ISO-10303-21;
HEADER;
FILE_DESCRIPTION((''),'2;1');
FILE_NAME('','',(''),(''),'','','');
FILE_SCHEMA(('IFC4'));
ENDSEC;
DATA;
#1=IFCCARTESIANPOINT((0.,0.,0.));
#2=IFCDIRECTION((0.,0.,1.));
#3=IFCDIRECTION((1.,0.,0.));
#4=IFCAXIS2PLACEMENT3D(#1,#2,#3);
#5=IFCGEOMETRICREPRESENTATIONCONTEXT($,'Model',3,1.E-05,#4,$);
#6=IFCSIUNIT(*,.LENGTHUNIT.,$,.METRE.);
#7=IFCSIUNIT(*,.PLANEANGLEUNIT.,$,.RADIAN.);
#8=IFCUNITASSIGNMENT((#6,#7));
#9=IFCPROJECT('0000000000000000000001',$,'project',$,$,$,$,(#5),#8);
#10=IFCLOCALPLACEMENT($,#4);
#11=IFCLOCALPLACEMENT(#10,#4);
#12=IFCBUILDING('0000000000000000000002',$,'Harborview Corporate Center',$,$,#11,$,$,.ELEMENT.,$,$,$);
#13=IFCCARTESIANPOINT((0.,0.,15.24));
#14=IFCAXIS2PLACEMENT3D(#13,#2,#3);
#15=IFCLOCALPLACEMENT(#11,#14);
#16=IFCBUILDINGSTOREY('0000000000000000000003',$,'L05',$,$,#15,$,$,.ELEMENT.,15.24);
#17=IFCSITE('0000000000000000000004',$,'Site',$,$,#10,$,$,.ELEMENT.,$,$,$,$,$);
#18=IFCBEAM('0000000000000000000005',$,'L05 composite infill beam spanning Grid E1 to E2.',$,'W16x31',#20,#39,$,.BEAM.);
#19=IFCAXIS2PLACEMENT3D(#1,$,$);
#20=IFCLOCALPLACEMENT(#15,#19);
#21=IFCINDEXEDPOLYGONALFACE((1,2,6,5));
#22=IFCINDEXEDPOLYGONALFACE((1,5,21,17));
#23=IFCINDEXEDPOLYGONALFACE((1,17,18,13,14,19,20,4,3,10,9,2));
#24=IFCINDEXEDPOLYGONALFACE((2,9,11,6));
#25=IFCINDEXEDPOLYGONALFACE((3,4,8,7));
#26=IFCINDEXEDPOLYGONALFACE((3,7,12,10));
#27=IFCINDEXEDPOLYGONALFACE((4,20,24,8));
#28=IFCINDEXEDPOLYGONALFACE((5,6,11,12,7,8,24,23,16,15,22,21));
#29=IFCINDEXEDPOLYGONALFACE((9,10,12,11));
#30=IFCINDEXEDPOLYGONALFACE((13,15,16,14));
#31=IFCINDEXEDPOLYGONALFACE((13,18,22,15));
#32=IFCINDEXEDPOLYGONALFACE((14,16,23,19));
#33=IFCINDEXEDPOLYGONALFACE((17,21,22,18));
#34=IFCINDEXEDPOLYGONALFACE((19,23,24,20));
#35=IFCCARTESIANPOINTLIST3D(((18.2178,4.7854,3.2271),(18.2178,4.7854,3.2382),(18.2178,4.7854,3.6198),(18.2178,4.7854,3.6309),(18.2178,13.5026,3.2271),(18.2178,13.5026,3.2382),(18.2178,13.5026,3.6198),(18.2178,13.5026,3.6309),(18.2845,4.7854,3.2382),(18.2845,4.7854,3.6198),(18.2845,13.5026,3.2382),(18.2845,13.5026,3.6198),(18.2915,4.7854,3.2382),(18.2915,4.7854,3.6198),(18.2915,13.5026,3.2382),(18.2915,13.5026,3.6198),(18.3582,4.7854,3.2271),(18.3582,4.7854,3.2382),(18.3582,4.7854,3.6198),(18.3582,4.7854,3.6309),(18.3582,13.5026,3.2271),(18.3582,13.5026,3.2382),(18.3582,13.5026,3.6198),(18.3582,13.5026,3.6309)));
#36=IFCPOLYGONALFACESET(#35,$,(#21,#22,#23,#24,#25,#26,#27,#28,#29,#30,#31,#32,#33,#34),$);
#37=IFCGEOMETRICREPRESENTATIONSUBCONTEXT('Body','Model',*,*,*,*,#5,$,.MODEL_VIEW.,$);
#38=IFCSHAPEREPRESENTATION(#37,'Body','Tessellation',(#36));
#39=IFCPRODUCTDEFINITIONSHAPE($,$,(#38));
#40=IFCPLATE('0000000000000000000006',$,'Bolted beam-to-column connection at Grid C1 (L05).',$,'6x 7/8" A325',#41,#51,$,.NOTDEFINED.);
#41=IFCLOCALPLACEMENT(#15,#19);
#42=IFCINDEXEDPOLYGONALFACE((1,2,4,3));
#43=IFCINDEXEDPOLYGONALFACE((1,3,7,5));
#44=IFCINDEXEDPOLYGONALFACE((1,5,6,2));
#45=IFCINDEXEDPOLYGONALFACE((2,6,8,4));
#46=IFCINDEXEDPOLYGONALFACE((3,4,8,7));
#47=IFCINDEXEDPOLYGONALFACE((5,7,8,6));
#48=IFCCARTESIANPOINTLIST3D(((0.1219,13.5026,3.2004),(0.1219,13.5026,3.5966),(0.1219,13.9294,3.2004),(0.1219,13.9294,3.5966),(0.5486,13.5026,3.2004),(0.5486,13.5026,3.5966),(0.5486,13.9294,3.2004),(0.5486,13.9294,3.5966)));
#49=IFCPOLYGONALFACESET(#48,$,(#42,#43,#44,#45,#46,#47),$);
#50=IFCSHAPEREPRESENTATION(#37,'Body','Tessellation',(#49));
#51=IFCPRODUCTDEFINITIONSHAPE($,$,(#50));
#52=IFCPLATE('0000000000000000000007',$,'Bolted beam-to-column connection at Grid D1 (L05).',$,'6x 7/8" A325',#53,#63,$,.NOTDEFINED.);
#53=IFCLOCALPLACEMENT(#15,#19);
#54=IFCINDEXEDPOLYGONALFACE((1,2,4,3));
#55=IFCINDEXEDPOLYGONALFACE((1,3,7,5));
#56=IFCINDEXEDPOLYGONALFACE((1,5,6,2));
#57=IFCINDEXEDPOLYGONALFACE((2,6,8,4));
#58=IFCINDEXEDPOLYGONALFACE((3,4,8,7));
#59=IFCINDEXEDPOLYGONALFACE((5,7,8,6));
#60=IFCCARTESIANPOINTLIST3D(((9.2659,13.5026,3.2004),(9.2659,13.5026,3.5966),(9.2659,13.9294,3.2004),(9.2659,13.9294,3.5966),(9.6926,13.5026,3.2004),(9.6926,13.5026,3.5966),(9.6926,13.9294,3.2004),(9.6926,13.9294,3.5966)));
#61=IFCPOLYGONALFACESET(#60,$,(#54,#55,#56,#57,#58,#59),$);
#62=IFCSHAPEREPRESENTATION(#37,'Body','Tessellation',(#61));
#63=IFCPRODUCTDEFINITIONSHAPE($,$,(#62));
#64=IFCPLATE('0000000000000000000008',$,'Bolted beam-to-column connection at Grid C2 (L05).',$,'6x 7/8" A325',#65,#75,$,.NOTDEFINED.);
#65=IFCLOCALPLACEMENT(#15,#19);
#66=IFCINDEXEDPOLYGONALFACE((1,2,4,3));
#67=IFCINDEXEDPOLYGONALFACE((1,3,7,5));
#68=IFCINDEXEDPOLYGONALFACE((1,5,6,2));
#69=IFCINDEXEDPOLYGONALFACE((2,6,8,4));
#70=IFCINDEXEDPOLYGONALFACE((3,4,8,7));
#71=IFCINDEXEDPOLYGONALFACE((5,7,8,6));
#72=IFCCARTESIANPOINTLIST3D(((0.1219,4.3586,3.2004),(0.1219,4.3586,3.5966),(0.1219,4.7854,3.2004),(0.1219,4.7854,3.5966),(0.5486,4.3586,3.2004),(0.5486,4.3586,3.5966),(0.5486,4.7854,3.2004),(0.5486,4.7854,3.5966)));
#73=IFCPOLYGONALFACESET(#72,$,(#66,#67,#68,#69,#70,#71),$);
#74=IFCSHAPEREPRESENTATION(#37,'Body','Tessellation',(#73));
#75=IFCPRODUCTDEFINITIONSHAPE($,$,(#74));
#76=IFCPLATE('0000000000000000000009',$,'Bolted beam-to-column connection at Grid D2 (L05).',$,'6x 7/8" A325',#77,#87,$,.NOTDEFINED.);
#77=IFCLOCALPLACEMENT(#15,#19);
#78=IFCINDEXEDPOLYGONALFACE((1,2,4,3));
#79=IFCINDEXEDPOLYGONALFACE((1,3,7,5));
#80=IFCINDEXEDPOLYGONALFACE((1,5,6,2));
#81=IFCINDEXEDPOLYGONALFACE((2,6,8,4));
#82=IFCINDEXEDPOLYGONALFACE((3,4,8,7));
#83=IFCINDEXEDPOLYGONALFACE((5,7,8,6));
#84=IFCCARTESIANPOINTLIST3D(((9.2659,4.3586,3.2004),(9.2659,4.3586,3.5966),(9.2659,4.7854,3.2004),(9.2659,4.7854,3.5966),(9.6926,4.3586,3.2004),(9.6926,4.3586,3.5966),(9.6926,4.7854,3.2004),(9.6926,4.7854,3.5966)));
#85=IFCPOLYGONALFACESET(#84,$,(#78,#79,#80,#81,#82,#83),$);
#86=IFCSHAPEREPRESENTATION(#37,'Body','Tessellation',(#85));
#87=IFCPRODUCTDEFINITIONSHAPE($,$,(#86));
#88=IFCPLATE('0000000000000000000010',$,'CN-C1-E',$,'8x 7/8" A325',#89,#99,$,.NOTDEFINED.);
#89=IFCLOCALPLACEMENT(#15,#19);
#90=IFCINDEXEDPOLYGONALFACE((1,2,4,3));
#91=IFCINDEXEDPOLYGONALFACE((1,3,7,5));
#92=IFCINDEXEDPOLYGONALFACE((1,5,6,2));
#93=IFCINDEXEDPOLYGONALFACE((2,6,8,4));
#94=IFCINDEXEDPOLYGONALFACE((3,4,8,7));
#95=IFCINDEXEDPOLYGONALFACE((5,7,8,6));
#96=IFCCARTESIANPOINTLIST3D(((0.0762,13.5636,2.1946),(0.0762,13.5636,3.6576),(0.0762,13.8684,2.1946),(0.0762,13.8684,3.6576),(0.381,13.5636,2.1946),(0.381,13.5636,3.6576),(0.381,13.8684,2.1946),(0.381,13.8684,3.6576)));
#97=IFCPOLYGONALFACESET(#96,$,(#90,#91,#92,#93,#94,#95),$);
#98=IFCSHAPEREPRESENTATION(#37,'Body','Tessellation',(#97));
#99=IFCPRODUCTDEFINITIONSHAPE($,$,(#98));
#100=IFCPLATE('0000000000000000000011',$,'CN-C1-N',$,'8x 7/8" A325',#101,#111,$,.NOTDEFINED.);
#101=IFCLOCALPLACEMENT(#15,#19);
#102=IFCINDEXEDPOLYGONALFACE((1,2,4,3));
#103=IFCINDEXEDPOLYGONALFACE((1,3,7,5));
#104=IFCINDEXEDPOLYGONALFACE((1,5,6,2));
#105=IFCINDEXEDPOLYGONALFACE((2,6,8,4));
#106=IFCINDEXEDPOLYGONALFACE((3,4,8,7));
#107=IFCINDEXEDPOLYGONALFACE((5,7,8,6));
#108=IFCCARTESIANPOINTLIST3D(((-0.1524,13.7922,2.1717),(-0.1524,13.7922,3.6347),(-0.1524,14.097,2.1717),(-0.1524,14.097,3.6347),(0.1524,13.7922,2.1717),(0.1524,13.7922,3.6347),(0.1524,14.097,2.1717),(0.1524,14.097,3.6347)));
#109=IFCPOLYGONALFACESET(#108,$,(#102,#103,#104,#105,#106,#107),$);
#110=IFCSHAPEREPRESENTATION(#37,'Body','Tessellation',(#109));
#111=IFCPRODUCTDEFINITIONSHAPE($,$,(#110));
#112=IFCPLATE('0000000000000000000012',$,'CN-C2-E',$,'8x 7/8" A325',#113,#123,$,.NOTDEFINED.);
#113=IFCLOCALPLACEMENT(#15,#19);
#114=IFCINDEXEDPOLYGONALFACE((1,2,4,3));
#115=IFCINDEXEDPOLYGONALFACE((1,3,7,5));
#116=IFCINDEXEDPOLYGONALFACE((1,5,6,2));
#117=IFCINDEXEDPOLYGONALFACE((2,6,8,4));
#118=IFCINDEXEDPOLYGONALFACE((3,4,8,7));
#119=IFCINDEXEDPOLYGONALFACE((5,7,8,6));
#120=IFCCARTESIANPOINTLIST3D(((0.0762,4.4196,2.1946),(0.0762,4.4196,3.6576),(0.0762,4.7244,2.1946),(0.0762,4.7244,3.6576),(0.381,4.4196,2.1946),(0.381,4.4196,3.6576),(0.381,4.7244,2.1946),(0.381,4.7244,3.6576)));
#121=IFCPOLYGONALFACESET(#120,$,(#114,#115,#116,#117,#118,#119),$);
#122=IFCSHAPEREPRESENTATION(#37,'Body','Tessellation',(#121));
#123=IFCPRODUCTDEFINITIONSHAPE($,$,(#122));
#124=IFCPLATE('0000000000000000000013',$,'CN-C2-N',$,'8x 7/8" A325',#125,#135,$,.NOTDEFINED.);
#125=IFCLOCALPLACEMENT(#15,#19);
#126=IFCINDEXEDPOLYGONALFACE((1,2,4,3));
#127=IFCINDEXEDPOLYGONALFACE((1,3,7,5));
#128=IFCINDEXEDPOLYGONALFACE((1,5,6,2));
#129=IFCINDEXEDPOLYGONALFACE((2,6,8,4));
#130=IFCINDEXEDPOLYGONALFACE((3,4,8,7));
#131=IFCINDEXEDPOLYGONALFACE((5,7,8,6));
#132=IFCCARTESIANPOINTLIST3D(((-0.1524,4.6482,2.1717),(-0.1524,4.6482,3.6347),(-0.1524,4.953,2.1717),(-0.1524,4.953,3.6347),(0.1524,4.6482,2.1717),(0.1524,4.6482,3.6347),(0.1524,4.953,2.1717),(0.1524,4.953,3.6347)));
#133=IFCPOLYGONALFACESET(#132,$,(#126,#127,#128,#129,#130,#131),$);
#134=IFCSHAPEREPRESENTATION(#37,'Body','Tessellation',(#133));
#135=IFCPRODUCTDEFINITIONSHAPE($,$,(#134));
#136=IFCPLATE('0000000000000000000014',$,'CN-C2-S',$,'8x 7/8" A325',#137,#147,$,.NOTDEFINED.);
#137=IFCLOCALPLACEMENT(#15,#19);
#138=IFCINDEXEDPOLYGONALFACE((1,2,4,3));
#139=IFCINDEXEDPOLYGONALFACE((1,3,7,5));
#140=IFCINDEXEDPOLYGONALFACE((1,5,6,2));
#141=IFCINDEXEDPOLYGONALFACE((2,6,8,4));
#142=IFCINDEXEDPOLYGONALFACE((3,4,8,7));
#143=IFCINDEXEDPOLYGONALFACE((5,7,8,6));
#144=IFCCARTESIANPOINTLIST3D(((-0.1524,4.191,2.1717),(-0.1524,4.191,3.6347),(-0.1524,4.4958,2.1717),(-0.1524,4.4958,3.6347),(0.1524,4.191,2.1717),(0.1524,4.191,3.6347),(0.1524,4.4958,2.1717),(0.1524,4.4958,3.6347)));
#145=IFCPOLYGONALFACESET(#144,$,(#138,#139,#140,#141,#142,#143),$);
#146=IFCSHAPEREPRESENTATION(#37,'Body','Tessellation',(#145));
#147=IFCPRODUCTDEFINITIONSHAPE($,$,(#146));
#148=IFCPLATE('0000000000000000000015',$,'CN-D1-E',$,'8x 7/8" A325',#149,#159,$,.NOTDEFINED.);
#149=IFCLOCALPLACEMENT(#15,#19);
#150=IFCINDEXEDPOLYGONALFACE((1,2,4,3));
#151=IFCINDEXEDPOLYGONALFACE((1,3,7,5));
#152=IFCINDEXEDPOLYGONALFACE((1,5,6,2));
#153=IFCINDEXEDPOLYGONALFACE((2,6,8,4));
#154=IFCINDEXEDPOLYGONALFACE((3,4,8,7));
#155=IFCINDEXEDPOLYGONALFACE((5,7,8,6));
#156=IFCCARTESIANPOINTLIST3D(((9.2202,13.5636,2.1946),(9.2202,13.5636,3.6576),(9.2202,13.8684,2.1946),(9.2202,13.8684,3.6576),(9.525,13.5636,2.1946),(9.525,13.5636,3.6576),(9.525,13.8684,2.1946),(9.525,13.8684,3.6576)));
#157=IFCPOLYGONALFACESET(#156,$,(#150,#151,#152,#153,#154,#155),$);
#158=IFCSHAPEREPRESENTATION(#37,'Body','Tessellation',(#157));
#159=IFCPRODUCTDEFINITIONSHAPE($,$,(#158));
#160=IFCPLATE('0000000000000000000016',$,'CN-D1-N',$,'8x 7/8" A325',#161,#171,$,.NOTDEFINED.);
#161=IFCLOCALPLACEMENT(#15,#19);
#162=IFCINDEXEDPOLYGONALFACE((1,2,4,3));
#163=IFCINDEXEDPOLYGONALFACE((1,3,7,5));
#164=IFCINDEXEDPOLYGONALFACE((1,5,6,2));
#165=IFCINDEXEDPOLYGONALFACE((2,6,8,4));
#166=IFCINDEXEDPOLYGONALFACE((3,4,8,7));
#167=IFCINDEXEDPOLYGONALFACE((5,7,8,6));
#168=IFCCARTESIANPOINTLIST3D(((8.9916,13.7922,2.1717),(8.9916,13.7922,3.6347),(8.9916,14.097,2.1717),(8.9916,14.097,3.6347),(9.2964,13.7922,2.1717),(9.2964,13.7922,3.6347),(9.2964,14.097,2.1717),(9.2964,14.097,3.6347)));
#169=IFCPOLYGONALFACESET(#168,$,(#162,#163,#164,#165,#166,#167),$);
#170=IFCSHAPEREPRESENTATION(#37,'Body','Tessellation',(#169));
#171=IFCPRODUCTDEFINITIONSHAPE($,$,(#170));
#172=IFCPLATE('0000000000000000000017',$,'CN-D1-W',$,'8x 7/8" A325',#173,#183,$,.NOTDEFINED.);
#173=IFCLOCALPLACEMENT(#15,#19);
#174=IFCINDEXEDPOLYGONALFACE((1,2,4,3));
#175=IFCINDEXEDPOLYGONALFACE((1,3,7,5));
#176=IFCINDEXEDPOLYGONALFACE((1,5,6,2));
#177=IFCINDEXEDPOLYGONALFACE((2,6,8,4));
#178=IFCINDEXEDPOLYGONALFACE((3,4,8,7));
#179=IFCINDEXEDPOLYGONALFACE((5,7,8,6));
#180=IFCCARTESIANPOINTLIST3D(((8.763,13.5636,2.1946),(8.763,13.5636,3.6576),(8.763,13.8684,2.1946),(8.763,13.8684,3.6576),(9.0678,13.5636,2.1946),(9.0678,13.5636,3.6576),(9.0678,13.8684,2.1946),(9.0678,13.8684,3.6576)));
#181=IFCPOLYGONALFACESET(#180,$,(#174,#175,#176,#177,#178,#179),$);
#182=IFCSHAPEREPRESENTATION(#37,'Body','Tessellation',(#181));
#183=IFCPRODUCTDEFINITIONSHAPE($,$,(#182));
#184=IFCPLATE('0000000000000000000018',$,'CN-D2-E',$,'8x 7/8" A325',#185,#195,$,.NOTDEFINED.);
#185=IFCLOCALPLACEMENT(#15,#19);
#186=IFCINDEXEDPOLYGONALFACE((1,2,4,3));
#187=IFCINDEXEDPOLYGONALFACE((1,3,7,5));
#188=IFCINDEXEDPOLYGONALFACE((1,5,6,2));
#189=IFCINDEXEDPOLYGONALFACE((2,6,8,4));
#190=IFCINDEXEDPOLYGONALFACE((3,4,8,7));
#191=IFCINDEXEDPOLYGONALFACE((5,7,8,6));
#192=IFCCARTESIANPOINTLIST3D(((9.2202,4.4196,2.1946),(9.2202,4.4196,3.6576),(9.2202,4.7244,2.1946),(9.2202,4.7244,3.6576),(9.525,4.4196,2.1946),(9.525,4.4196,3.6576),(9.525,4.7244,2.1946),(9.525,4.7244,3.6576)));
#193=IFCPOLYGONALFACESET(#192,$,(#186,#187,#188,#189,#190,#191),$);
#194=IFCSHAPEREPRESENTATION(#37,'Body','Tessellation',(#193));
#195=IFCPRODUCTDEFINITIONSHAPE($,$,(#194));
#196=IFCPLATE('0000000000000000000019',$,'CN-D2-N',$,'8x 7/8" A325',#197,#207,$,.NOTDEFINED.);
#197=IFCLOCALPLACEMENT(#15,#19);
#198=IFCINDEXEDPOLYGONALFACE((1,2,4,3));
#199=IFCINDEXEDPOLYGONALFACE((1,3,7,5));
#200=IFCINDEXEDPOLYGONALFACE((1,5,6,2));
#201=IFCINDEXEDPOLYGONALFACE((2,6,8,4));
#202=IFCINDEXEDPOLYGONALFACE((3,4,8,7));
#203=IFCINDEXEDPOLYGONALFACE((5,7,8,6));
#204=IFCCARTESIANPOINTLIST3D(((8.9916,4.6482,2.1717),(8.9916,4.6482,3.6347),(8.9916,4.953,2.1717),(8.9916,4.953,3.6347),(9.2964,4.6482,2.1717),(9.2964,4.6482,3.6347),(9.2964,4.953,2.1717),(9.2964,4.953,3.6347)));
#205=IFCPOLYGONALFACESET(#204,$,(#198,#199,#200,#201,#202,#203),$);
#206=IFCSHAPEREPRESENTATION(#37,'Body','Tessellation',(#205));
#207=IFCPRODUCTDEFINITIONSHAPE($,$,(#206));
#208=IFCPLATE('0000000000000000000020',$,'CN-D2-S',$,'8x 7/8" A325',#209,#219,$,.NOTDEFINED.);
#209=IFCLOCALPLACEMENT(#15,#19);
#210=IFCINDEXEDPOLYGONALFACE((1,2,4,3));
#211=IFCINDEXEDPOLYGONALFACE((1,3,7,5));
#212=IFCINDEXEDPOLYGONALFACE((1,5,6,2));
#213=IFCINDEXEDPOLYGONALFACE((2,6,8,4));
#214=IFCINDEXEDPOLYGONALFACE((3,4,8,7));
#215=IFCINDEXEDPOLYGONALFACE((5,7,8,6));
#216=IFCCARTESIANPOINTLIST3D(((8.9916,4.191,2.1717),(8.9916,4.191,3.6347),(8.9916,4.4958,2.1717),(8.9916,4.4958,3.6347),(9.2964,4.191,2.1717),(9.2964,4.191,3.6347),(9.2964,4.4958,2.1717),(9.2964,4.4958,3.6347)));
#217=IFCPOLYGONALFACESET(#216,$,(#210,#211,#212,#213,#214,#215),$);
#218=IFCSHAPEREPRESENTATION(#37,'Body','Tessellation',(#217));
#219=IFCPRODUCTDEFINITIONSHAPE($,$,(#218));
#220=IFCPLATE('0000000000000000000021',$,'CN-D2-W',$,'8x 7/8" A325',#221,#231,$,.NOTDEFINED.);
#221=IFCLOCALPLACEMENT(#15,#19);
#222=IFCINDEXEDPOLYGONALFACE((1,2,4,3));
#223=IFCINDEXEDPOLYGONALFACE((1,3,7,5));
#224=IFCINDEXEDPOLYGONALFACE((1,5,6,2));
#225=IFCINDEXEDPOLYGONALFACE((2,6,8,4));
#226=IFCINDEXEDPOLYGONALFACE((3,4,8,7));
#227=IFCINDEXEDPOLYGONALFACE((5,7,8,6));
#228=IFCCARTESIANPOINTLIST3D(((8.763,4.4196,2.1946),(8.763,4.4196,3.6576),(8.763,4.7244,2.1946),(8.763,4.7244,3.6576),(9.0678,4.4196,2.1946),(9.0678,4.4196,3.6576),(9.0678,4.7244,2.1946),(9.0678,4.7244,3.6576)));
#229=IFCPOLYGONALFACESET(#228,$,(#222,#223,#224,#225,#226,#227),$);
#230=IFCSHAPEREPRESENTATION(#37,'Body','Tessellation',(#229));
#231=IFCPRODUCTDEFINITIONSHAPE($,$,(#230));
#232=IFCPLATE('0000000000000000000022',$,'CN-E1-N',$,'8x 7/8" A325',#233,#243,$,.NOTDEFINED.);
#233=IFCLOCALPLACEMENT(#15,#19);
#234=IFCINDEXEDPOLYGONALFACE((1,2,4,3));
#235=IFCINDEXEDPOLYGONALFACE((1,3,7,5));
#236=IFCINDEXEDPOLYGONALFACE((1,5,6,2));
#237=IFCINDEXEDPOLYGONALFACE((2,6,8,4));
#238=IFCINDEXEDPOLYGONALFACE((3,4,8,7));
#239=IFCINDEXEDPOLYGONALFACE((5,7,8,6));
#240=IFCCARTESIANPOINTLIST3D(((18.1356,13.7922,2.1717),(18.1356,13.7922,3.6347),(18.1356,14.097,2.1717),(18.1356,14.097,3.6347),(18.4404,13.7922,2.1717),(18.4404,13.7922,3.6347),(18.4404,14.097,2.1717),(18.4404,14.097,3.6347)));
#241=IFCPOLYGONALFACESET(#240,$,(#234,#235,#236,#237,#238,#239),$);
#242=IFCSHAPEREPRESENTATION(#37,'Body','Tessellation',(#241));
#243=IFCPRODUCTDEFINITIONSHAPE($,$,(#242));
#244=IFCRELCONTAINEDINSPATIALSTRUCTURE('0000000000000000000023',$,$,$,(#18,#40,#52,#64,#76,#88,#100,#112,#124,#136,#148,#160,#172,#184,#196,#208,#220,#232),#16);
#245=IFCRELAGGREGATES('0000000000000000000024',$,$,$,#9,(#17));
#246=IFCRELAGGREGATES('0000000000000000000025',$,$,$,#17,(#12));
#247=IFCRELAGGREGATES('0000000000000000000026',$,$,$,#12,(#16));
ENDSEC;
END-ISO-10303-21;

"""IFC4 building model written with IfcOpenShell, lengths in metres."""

from ifc_helpers import new_model, si_unit, frame, origin_with_axes, place, context, subcontext, project, spatial, rectangle, i_section, extrude, element, save


model = new_model("IFC4")

# Units and contexts
model_context = context("Model", 3, precision=1e-05, world=origin_with_axes())
body_context = subcontext(model_context, "Body", "Model", "MODEL_VIEW")
ifc_project = project(units=[si_unit("LENGTHUNIT", "METRE"), si_unit("PLANEANGLEUNIT", "RADIAN")], contexts=[model_context])

# Site, building, storey
site_placement = place(None, origin_with_axes())
site = spatial("IfcSite", under=ifc_project, at=site_placement, Name="Site", CompositionType="ELEMENT")
building_placement = place(site_placement, origin_with_axes())
building = spatial("IfcBuilding", under=site, at=building_placement, Name="Harborview Corporate Center", CompositionType="ELEMENT")
storey_placement = place(building_placement, frame((0.0, 0.0, 15.24), z_axis=(0.0, 0.0, 1.0), x_axis=(1.0, 0.0, 0.0)))
storey = spatial("IfcBuildingStorey", under=building, at=storey_placement, Name="L05", CompositionType="ELEMENT", Elevation=15.24)

# Beam
for number, where, z_axis, x_axis, name in (
    (1, (18.288, 4.7854, 3.429), (0.0, 1.0, 0.0), (-1.0, 0.0, 0.0), "L05 composite infill beam spanning Grid E1 to E2."),
):
    element("IfcBeam", number, at=place(storey_placement, frame(where, z_axis=z_axis, x_axis=x_axis)), inside=storey, Name=name, ObjectType="W16x31", PredefinedType="BEAM", context=body_context, shape_type="SweptSolid", body=[
        extrude(i_section(OverallWidth=0.1405, OverallDepth=0.4039, WebThickness=0.007, FlangeThickness=0.0112), origin_with_axes(), (0.0, 0.0, 1.0), 8.7173),
    ])

# Plates
plate_1_placement = place(storey_placement, frame((0.3353, 13.716, 3.2004), z_axis=(0.0, 0.0, 1.0), x_axis=(1.0, 0.0, 0.0)))
element("IfcPlate", 2, at=plate_1_placement, inside=storey, Name="Bolted beam-to-column connection at Grid C1 (L05).", ObjectType="6x 7/8\" A325", PredefinedType="NOTDEFINED", context=body_context, shape_type="SweptSolid", body=[
    extrude(rectangle(XDim=0.4267, YDim=0.4267), origin_with_axes(), (0.0, 0.0, 1.0), 0.3962),
])
plate_2_placement = place(storey_placement, frame((9.4793, 13.716, 3.2004), z_axis=(0.0, 0.0, 1.0), x_axis=(1.0, 0.0, 0.0)))
element("IfcPlate", 3, at=plate_2_placement, inside=storey, Name="Bolted beam-to-column connection at Grid D1 (L05).", ObjectType="6x 7/8\" A325", PredefinedType="NOTDEFINED", context=body_context, shape_type="SweptSolid", body=[
    extrude(rectangle(XDim=0.4267, YDim=0.4267), origin_with_axes(), (0.0, 0.0, 1.0), 0.3962),
])
plate_3_placement = place(storey_placement, frame((0.3353, 4.572, 3.2004), z_axis=(0.0, 0.0, 1.0), x_axis=(1.0, 0.0, 0.0)))
element("IfcPlate", 4, at=plate_3_placement, inside=storey, Name="Bolted beam-to-column connection at Grid C2 (L05).", ObjectType="6x 7/8\" A325", PredefinedType="NOTDEFINED", context=body_context, shape_type="SweptSolid", body=[
    extrude(rectangle(XDim=0.4267, YDim=0.4267), origin_with_axes(), (0.0, 0.0, 1.0), 0.3962),
])
plate_4_placement = place(storey_placement, frame((9.4793, 4.572, 3.2004), z_axis=(0.0, 0.0, 1.0), x_axis=(1.0, 0.0, 0.0)))
element("IfcPlate", 5, at=plate_4_placement, inside=storey, Name="Bolted beam-to-column connection at Grid D2 (L05).", ObjectType="6x 7/8\" A325", PredefinedType="NOTDEFINED", context=body_context, shape_type="SweptSolid", body=[
    extrude(rectangle(XDim=0.4267, YDim=0.4267), origin_with_axes(), (0.0, 0.0, 1.0), 0.3962),
])
for number, where, z_axis, x_axis, name in (
    (6, (0.2286, 13.716, 2.1946), (0.0, 0.0, 1.0), (1.0, 0.0, 0.0), "CN-C1-E"),
    (7, (0.0, 13.9446, 2.1717), (0.0, 0.0, 1.0), (1.0, 0.0, 0.0), "CN-C1-N"),
    (8, (0.2286, 4.572, 2.1946), (0.0, 0.0, 1.0), (1.0, 0.0, 0.0), "CN-C2-E"),
    (9, (0.0, 4.8006, 2.1717), (0.0, 0.0, 1.0), (1.0, 0.0, 0.0), "CN-C2-N"),
    (10, (0.0, 4.3434, 2.1717), (0.0, 0.0, 1.0), (1.0, 0.0, 0.0), "CN-C2-S"),
):
    element("IfcPlate", number, at=place(storey_placement, frame(where, z_axis=z_axis, x_axis=x_axis)), inside=storey, Name=name, ObjectType="8x 7/8\" A325", PredefinedType="NOTDEFINED", context=body_context, shape_type="SweptSolid", body=[
        extrude(rectangle(XDim=0.3048, YDim=0.3048), origin_with_axes(), (0.0, 0.0, 1.0), 1.463),
    ])
for number, where, z_axis, x_axis, name in (
    (11, (9.3726, 13.716, 2.1946), (0.0, 0.0, 1.0), (1.0, 0.0, 0.0), "CN-D1-E"),
    (12, (9.144, 13.9446, 2.1717), (0.0, 0.0, 1.0), (1.0, 0.0, 0.0), "CN-D1-N"),
    (13, (8.9154, 13.716, 2.1946), (0.0, 0.0, 1.0), (1.0, 0.0, 0.0), "CN-D1-W"),
    (14, (9.3726, 4.572, 2.1946), (0.0, 0.0, 1.0), (1.0, 0.0, 0.0), "CN-D2-E"),
    (15, (9.144, 4.8006, 2.1717), (0.0, 0.0, 1.0), (1.0, 0.0, 0.0), "CN-D2-N"),
    (16, (9.144, 4.3434, 2.1717), (0.0, 0.0, 1.0), (1.0, 0.0, 0.0), "CN-D2-S"),
    (17, (8.9154, 4.572, 2.1946), (0.0, 0.0, 1.0), (1.0, 0.0, 0.0), "CN-D2-W"),
    (18, (18.288, 13.9446, 2.1717), (0.0, 0.0, 1.0), (1.0, 0.0, 0.0), "CN-E1-N"),
):
    element("IfcPlate", number, at=place(storey_placement, frame(where, z_axis=z_axis, x_axis=x_axis)), inside=storey, Name=name, ObjectType="8x 7/8\" A325", PredefinedType="NOTDEFINED", context=body_context, shape_type="SweptSolid", body=[
        extrude(rectangle(XDim=0.3048, YDim=0.3048), origin_with_axes(), (0.0, 0.0, 1.0), 1.463),
    ])

save(model, "model.ifc")
